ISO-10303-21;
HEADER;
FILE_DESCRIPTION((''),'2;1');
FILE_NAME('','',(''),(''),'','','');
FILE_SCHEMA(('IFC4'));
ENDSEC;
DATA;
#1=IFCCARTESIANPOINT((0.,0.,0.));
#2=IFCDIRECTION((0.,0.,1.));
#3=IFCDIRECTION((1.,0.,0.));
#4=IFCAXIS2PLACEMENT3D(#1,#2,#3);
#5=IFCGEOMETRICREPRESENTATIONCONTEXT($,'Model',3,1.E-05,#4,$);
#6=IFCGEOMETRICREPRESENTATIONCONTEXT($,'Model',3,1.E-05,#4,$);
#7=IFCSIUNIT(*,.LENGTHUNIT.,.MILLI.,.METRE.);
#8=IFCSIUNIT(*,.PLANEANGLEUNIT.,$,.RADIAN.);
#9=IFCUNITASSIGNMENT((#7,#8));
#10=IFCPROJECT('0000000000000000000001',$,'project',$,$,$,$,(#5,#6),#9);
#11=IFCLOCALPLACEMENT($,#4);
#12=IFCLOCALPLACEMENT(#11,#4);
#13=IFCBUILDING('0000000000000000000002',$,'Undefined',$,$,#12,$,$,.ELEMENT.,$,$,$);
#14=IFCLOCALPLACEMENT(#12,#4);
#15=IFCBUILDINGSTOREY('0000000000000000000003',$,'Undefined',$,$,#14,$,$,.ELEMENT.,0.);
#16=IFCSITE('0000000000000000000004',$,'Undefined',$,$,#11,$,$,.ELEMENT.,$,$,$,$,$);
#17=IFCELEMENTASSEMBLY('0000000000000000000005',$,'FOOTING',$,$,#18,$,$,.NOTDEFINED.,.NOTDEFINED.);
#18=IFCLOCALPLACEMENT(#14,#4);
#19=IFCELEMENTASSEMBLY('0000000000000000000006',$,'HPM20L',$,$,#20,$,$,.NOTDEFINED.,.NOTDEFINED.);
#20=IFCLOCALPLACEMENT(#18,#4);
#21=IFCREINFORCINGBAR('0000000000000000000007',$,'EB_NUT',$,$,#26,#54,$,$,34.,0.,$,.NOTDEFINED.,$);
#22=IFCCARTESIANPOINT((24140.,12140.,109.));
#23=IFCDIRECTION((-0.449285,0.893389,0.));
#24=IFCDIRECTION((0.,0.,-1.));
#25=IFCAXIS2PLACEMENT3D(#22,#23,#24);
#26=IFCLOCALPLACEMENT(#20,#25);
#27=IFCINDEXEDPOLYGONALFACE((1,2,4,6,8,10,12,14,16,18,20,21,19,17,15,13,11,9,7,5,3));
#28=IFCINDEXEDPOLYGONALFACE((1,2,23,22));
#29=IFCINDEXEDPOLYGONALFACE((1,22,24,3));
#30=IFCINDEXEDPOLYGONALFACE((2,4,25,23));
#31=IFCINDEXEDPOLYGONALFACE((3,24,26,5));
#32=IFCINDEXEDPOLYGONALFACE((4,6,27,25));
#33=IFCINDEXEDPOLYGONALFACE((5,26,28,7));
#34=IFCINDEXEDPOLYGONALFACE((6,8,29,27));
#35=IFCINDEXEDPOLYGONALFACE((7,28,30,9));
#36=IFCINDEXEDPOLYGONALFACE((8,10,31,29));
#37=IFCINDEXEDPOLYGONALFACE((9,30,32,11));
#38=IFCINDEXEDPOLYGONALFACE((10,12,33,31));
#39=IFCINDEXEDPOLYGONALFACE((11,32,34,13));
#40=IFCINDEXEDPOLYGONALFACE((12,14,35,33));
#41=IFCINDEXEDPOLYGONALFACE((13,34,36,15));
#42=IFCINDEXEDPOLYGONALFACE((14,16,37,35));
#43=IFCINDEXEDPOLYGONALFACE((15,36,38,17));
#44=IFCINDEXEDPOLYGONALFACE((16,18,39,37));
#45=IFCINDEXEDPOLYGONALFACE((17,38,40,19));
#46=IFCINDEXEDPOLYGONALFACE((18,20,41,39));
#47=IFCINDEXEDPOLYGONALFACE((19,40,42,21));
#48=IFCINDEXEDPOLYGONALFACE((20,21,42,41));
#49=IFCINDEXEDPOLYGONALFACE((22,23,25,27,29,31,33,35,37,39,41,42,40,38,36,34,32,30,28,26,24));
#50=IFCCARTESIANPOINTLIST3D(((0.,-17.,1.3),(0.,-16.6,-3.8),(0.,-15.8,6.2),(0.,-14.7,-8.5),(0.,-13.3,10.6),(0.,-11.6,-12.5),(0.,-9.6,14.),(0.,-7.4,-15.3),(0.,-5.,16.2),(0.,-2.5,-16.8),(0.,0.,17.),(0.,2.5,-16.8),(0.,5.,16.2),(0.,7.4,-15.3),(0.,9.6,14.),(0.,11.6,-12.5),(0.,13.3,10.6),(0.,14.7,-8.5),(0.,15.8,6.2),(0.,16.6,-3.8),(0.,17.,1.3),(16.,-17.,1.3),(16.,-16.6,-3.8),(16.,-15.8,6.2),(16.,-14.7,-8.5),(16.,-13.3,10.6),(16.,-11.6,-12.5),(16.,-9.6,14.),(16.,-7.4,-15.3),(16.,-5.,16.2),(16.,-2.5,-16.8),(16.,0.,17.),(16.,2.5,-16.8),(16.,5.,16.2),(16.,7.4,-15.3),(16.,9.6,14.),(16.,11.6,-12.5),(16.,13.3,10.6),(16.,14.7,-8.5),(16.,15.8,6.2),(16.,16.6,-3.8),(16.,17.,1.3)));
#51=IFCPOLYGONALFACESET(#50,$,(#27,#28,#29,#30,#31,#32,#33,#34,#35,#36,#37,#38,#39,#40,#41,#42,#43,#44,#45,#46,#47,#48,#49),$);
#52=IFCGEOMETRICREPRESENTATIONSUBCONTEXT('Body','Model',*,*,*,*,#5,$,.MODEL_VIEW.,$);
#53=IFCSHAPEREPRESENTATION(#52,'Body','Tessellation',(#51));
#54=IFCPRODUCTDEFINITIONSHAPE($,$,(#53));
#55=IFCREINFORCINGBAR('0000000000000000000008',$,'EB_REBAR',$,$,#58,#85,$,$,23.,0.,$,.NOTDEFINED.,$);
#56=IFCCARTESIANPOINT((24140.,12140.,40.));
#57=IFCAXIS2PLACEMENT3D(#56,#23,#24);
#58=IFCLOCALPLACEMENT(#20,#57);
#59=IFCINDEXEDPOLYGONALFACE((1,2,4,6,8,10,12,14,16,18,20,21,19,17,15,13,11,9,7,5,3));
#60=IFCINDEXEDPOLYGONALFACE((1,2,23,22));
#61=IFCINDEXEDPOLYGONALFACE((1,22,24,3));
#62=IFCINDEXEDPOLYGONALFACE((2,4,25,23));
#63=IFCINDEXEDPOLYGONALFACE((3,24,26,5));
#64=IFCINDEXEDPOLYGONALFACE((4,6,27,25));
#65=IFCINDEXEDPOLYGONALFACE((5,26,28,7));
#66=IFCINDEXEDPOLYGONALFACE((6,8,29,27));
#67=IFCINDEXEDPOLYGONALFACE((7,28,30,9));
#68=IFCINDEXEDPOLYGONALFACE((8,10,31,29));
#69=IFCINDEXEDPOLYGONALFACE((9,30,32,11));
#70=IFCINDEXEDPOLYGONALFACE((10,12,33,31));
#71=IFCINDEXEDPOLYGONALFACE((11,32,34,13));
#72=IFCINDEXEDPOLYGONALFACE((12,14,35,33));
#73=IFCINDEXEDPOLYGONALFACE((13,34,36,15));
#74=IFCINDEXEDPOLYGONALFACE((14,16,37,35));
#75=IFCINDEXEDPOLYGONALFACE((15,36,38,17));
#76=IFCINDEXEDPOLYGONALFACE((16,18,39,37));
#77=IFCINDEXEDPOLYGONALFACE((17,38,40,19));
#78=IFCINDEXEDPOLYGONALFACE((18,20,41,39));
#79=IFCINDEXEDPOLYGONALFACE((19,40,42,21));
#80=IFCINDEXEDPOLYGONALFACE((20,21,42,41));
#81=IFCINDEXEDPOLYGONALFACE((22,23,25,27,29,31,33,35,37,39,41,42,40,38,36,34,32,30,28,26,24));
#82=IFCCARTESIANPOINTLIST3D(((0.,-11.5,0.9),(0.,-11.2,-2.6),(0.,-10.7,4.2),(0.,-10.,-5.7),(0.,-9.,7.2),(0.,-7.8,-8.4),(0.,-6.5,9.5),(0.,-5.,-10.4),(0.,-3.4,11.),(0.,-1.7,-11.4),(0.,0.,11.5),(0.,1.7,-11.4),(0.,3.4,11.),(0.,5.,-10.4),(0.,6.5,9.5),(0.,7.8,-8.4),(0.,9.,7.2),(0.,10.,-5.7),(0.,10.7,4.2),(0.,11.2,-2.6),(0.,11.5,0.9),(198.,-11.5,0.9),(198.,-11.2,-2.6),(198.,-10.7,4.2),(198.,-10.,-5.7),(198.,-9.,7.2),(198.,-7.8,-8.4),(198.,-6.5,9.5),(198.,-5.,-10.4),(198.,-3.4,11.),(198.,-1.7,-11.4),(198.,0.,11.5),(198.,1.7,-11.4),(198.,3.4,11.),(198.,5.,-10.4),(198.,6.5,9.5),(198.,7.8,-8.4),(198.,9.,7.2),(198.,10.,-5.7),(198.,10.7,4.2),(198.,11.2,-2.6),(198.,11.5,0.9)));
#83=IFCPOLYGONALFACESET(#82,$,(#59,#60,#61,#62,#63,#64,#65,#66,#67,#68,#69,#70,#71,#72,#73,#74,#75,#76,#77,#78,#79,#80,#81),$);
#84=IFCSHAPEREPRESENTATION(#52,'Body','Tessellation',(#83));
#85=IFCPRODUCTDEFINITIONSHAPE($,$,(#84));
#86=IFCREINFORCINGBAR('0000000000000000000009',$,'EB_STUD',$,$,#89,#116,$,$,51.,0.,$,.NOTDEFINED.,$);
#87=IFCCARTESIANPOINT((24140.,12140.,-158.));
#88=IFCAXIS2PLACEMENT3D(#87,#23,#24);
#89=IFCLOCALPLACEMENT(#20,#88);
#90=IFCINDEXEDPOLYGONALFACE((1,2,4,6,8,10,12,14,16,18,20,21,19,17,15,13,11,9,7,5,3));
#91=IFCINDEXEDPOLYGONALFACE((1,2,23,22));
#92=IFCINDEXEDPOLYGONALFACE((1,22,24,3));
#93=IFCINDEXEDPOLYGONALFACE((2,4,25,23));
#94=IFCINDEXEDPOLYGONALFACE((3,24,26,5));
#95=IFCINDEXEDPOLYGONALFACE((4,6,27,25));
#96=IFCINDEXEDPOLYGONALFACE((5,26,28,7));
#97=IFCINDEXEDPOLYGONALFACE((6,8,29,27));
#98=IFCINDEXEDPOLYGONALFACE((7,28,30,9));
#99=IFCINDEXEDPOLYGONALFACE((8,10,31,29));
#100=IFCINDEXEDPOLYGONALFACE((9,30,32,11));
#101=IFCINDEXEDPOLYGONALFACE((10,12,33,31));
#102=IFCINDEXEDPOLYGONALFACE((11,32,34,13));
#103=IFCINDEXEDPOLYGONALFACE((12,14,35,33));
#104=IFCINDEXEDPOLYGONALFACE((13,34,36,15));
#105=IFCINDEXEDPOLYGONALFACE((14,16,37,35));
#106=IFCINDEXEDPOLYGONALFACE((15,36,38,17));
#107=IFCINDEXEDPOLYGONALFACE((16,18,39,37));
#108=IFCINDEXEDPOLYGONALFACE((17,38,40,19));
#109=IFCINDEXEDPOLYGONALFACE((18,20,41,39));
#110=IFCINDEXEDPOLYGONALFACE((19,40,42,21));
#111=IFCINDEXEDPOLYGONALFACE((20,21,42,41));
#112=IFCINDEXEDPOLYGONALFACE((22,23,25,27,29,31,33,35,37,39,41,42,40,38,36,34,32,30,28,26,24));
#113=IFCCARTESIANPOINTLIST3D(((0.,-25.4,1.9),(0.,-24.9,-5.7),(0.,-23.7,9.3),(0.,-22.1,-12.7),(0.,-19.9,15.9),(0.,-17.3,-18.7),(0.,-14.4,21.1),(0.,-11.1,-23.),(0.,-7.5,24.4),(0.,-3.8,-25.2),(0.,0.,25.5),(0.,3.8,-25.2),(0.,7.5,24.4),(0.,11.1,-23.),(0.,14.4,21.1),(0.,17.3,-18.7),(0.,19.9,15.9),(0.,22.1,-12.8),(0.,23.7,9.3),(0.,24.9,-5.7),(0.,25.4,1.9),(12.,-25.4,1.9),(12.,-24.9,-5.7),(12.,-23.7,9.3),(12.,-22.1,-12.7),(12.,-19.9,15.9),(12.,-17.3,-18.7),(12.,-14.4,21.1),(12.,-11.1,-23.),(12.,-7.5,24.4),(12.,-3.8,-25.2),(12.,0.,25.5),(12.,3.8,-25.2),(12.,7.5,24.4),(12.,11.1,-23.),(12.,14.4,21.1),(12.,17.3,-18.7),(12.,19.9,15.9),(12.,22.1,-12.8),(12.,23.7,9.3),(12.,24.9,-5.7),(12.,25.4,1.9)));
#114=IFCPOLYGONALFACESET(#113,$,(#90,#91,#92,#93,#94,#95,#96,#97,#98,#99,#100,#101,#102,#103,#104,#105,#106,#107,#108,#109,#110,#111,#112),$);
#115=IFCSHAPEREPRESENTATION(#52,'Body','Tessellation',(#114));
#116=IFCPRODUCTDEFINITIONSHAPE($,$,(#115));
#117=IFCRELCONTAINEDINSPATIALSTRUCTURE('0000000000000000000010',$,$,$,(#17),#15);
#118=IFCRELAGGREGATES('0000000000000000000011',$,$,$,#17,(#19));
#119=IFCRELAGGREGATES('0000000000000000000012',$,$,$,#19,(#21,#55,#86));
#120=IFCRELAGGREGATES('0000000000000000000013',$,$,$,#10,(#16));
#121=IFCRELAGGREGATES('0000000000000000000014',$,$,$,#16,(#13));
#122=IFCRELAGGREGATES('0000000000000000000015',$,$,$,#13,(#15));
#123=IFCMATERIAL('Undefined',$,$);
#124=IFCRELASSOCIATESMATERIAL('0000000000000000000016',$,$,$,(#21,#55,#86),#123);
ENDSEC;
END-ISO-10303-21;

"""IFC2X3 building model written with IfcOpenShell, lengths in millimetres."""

from ifc_helpers import new_model, entity, si_unit, frame, origin_with_axes, place, context, subcontext, project, spatial, source, transform, mapped, material, element, aggregate, save


model = new_model("IFC2X3")

# Units and contexts
model_context_1 = context("Model", 3, precision=1e-05, world=origin_with_axes())
model_context_2 = context("Model", 3, precision=1e-05, world=origin_with_axes())
body_context = subcontext(model_context_1, "Body", "Model", "MODEL_VIEW")
ifc_project = project(units=[si_unit("LENGTHUNIT", "METRE", prefix="MILLI"), si_unit("PLANEANGLEUNIT", "RADIAN")], contexts=[model_context_1, model_context_2])

# Site, building, storey
site_placement = place(None, origin_with_axes())
site = spatial("IfcSite", under=ifc_project, at=site_placement, Name="Undefined", CompositionType="ELEMENT")
building_placement = place(site_placement, origin_with_axes())
building = spatial("IfcBuilding", under=site, at=building_placement, Name="Undefined", CompositionType="ELEMENT")
storey_placement = place(building_placement, origin_with_axes())
storey = spatial("IfcBuildingStorey", under=building, at=storey_placement, Name="Undefined", CompositionType="ELEMENT", Elevation=0.0)

# Element assembly
assembly_1_placement = place(storey_placement, origin_with_axes())
assembly_1 = element("IfcElementAssembly", 1, at=assembly_1_placement, inside=storey, Name="FOOTING", AssemblyPlace="NOTDEFINED", PredefinedType="NOTDEFINED")

# Element assembly
assembly_2_placement = place(assembly_1_placement, origin_with_axes())
assembly_2 = element("IfcElementAssembly", 2, at=assembly_2_placement, Name="HPM20L", AssemblyPlace="NOTDEFINED", PredefinedType="NOTDEFINED")
aggregate(assembly_1, [assembly_2])

# Shared definitions
ifc_material_1 = material(Name="Undefined")

# Reinforcing bars
shared_shape_1 = source(origin_with_axes(), body_context, "Body", "AdvancedSweptSolid", [
    entity("IfcSweptDiskSolid", entity("IfcTrimmedCurve", entity("IfcLine", entity("IfcCartesianPoint", [0.0, 0.0, 0.0]), entity("IfcVector", entity("IfcDirection", [1.0, 0.0, 0.0]), 1.0)), [entity("IfcParameterValue", 0.0)], [entity("IfcParameterValue", 16.0)], True, "PARAMETER"), 17.0, None, 0.0, 16.0),
])
reinforcing_bar_1_placement = place(assembly_2_placement, frame((24140.0, 12140.0, 109.0), z_axis=(-0.449285, 0.893389, 0.0), x_axis=(0.0, 0.0, -1.0)))
reinforcing_bar_1 = element("IfcReinforcingBar", 3, at=reinforcing_bar_1_placement, material=ifc_material_1, Name="EB_NUT", BarRole="NOTDEFINED", CrossSectionArea=0.0, NominalDiameter=34.0, context=body_context, shape_type="MappedRepresentation", body=[
    mapped(shared_shape_1, transform((0.0, 0.0, 0.0))),
])
shared_shape_2 = source(origin_with_axes(), body_context, "Body", "AdvancedSweptSolid", [
    entity("IfcSweptDiskSolid", entity("IfcTrimmedCurve", entity("IfcLine", entity("IfcCartesianPoint", [0.0, 0.0, 0.0]), entity("IfcVector", entity("IfcDirection", [1.0, 0.0, 0.0]), 1.0)), [entity("IfcParameterValue", 0.0)], [entity("IfcParameterValue", 198.0)], True, "PARAMETER"), 11.5, None, 0.0, 198.0),
])
reinforcing_bar_2_placement = place(assembly_2_placement, frame((24140.0, 12140.0, 40.0), z_axis=(-0.449285, 0.893389, 0.0), x_axis=(0.0, 0.0, -1.0)))
reinforcing_bar_2 = element("IfcReinforcingBar", 4, at=reinforcing_bar_2_placement, material=ifc_material_1, Name="EB_REBAR", BarRole="NOTDEFINED", CrossSectionArea=0.0, NominalDiameter=23.0, context=body_context, shape_type="MappedRepresentation", body=[
    mapped(shared_shape_2, transform((0.0, 0.0, 0.0))),
])
shared_shape_3 = source(origin_with_axes(), body_context, "Body", "AdvancedSweptSolid", [
    entity("IfcSweptDiskSolid", entity("IfcTrimmedCurve", entity("IfcLine", entity("IfcCartesianPoint", [0.0, 0.0, 0.0]), entity("IfcVector", entity("IfcDirection", [1.0, 0.0, 0.0]), 1.0)), [entity("IfcParameterValue", 0.0)], [entity("IfcParameterValue", 12.0)], True, "PARAMETER"), 25.5, None, 0.0, 12.0),
])
reinforcing_bar_3_placement = place(assembly_2_placement, frame((24140.0, 12140.0, -158.0), z_axis=(-0.449285, 0.893389, 0.0), x_axis=(0.0, 0.0, -1.0)))
reinforcing_bar_3 = element("IfcReinforcingBar", 5, at=reinforcing_bar_3_placement, material=ifc_material_1, Name="EB_STUD", BarRole="NOTDEFINED", CrossSectionArea=0.0, NominalDiameter=51.0, context=body_context, shape_type="MappedRepresentation", body=[
    mapped(shared_shape_3, transform((0.0, 0.0, 0.0))),
])
aggregate(assembly_2, [reinforcing_bar_1, reinforcing_bar_2, reinforcing_bar_3])

save(model, "model.ifc")
